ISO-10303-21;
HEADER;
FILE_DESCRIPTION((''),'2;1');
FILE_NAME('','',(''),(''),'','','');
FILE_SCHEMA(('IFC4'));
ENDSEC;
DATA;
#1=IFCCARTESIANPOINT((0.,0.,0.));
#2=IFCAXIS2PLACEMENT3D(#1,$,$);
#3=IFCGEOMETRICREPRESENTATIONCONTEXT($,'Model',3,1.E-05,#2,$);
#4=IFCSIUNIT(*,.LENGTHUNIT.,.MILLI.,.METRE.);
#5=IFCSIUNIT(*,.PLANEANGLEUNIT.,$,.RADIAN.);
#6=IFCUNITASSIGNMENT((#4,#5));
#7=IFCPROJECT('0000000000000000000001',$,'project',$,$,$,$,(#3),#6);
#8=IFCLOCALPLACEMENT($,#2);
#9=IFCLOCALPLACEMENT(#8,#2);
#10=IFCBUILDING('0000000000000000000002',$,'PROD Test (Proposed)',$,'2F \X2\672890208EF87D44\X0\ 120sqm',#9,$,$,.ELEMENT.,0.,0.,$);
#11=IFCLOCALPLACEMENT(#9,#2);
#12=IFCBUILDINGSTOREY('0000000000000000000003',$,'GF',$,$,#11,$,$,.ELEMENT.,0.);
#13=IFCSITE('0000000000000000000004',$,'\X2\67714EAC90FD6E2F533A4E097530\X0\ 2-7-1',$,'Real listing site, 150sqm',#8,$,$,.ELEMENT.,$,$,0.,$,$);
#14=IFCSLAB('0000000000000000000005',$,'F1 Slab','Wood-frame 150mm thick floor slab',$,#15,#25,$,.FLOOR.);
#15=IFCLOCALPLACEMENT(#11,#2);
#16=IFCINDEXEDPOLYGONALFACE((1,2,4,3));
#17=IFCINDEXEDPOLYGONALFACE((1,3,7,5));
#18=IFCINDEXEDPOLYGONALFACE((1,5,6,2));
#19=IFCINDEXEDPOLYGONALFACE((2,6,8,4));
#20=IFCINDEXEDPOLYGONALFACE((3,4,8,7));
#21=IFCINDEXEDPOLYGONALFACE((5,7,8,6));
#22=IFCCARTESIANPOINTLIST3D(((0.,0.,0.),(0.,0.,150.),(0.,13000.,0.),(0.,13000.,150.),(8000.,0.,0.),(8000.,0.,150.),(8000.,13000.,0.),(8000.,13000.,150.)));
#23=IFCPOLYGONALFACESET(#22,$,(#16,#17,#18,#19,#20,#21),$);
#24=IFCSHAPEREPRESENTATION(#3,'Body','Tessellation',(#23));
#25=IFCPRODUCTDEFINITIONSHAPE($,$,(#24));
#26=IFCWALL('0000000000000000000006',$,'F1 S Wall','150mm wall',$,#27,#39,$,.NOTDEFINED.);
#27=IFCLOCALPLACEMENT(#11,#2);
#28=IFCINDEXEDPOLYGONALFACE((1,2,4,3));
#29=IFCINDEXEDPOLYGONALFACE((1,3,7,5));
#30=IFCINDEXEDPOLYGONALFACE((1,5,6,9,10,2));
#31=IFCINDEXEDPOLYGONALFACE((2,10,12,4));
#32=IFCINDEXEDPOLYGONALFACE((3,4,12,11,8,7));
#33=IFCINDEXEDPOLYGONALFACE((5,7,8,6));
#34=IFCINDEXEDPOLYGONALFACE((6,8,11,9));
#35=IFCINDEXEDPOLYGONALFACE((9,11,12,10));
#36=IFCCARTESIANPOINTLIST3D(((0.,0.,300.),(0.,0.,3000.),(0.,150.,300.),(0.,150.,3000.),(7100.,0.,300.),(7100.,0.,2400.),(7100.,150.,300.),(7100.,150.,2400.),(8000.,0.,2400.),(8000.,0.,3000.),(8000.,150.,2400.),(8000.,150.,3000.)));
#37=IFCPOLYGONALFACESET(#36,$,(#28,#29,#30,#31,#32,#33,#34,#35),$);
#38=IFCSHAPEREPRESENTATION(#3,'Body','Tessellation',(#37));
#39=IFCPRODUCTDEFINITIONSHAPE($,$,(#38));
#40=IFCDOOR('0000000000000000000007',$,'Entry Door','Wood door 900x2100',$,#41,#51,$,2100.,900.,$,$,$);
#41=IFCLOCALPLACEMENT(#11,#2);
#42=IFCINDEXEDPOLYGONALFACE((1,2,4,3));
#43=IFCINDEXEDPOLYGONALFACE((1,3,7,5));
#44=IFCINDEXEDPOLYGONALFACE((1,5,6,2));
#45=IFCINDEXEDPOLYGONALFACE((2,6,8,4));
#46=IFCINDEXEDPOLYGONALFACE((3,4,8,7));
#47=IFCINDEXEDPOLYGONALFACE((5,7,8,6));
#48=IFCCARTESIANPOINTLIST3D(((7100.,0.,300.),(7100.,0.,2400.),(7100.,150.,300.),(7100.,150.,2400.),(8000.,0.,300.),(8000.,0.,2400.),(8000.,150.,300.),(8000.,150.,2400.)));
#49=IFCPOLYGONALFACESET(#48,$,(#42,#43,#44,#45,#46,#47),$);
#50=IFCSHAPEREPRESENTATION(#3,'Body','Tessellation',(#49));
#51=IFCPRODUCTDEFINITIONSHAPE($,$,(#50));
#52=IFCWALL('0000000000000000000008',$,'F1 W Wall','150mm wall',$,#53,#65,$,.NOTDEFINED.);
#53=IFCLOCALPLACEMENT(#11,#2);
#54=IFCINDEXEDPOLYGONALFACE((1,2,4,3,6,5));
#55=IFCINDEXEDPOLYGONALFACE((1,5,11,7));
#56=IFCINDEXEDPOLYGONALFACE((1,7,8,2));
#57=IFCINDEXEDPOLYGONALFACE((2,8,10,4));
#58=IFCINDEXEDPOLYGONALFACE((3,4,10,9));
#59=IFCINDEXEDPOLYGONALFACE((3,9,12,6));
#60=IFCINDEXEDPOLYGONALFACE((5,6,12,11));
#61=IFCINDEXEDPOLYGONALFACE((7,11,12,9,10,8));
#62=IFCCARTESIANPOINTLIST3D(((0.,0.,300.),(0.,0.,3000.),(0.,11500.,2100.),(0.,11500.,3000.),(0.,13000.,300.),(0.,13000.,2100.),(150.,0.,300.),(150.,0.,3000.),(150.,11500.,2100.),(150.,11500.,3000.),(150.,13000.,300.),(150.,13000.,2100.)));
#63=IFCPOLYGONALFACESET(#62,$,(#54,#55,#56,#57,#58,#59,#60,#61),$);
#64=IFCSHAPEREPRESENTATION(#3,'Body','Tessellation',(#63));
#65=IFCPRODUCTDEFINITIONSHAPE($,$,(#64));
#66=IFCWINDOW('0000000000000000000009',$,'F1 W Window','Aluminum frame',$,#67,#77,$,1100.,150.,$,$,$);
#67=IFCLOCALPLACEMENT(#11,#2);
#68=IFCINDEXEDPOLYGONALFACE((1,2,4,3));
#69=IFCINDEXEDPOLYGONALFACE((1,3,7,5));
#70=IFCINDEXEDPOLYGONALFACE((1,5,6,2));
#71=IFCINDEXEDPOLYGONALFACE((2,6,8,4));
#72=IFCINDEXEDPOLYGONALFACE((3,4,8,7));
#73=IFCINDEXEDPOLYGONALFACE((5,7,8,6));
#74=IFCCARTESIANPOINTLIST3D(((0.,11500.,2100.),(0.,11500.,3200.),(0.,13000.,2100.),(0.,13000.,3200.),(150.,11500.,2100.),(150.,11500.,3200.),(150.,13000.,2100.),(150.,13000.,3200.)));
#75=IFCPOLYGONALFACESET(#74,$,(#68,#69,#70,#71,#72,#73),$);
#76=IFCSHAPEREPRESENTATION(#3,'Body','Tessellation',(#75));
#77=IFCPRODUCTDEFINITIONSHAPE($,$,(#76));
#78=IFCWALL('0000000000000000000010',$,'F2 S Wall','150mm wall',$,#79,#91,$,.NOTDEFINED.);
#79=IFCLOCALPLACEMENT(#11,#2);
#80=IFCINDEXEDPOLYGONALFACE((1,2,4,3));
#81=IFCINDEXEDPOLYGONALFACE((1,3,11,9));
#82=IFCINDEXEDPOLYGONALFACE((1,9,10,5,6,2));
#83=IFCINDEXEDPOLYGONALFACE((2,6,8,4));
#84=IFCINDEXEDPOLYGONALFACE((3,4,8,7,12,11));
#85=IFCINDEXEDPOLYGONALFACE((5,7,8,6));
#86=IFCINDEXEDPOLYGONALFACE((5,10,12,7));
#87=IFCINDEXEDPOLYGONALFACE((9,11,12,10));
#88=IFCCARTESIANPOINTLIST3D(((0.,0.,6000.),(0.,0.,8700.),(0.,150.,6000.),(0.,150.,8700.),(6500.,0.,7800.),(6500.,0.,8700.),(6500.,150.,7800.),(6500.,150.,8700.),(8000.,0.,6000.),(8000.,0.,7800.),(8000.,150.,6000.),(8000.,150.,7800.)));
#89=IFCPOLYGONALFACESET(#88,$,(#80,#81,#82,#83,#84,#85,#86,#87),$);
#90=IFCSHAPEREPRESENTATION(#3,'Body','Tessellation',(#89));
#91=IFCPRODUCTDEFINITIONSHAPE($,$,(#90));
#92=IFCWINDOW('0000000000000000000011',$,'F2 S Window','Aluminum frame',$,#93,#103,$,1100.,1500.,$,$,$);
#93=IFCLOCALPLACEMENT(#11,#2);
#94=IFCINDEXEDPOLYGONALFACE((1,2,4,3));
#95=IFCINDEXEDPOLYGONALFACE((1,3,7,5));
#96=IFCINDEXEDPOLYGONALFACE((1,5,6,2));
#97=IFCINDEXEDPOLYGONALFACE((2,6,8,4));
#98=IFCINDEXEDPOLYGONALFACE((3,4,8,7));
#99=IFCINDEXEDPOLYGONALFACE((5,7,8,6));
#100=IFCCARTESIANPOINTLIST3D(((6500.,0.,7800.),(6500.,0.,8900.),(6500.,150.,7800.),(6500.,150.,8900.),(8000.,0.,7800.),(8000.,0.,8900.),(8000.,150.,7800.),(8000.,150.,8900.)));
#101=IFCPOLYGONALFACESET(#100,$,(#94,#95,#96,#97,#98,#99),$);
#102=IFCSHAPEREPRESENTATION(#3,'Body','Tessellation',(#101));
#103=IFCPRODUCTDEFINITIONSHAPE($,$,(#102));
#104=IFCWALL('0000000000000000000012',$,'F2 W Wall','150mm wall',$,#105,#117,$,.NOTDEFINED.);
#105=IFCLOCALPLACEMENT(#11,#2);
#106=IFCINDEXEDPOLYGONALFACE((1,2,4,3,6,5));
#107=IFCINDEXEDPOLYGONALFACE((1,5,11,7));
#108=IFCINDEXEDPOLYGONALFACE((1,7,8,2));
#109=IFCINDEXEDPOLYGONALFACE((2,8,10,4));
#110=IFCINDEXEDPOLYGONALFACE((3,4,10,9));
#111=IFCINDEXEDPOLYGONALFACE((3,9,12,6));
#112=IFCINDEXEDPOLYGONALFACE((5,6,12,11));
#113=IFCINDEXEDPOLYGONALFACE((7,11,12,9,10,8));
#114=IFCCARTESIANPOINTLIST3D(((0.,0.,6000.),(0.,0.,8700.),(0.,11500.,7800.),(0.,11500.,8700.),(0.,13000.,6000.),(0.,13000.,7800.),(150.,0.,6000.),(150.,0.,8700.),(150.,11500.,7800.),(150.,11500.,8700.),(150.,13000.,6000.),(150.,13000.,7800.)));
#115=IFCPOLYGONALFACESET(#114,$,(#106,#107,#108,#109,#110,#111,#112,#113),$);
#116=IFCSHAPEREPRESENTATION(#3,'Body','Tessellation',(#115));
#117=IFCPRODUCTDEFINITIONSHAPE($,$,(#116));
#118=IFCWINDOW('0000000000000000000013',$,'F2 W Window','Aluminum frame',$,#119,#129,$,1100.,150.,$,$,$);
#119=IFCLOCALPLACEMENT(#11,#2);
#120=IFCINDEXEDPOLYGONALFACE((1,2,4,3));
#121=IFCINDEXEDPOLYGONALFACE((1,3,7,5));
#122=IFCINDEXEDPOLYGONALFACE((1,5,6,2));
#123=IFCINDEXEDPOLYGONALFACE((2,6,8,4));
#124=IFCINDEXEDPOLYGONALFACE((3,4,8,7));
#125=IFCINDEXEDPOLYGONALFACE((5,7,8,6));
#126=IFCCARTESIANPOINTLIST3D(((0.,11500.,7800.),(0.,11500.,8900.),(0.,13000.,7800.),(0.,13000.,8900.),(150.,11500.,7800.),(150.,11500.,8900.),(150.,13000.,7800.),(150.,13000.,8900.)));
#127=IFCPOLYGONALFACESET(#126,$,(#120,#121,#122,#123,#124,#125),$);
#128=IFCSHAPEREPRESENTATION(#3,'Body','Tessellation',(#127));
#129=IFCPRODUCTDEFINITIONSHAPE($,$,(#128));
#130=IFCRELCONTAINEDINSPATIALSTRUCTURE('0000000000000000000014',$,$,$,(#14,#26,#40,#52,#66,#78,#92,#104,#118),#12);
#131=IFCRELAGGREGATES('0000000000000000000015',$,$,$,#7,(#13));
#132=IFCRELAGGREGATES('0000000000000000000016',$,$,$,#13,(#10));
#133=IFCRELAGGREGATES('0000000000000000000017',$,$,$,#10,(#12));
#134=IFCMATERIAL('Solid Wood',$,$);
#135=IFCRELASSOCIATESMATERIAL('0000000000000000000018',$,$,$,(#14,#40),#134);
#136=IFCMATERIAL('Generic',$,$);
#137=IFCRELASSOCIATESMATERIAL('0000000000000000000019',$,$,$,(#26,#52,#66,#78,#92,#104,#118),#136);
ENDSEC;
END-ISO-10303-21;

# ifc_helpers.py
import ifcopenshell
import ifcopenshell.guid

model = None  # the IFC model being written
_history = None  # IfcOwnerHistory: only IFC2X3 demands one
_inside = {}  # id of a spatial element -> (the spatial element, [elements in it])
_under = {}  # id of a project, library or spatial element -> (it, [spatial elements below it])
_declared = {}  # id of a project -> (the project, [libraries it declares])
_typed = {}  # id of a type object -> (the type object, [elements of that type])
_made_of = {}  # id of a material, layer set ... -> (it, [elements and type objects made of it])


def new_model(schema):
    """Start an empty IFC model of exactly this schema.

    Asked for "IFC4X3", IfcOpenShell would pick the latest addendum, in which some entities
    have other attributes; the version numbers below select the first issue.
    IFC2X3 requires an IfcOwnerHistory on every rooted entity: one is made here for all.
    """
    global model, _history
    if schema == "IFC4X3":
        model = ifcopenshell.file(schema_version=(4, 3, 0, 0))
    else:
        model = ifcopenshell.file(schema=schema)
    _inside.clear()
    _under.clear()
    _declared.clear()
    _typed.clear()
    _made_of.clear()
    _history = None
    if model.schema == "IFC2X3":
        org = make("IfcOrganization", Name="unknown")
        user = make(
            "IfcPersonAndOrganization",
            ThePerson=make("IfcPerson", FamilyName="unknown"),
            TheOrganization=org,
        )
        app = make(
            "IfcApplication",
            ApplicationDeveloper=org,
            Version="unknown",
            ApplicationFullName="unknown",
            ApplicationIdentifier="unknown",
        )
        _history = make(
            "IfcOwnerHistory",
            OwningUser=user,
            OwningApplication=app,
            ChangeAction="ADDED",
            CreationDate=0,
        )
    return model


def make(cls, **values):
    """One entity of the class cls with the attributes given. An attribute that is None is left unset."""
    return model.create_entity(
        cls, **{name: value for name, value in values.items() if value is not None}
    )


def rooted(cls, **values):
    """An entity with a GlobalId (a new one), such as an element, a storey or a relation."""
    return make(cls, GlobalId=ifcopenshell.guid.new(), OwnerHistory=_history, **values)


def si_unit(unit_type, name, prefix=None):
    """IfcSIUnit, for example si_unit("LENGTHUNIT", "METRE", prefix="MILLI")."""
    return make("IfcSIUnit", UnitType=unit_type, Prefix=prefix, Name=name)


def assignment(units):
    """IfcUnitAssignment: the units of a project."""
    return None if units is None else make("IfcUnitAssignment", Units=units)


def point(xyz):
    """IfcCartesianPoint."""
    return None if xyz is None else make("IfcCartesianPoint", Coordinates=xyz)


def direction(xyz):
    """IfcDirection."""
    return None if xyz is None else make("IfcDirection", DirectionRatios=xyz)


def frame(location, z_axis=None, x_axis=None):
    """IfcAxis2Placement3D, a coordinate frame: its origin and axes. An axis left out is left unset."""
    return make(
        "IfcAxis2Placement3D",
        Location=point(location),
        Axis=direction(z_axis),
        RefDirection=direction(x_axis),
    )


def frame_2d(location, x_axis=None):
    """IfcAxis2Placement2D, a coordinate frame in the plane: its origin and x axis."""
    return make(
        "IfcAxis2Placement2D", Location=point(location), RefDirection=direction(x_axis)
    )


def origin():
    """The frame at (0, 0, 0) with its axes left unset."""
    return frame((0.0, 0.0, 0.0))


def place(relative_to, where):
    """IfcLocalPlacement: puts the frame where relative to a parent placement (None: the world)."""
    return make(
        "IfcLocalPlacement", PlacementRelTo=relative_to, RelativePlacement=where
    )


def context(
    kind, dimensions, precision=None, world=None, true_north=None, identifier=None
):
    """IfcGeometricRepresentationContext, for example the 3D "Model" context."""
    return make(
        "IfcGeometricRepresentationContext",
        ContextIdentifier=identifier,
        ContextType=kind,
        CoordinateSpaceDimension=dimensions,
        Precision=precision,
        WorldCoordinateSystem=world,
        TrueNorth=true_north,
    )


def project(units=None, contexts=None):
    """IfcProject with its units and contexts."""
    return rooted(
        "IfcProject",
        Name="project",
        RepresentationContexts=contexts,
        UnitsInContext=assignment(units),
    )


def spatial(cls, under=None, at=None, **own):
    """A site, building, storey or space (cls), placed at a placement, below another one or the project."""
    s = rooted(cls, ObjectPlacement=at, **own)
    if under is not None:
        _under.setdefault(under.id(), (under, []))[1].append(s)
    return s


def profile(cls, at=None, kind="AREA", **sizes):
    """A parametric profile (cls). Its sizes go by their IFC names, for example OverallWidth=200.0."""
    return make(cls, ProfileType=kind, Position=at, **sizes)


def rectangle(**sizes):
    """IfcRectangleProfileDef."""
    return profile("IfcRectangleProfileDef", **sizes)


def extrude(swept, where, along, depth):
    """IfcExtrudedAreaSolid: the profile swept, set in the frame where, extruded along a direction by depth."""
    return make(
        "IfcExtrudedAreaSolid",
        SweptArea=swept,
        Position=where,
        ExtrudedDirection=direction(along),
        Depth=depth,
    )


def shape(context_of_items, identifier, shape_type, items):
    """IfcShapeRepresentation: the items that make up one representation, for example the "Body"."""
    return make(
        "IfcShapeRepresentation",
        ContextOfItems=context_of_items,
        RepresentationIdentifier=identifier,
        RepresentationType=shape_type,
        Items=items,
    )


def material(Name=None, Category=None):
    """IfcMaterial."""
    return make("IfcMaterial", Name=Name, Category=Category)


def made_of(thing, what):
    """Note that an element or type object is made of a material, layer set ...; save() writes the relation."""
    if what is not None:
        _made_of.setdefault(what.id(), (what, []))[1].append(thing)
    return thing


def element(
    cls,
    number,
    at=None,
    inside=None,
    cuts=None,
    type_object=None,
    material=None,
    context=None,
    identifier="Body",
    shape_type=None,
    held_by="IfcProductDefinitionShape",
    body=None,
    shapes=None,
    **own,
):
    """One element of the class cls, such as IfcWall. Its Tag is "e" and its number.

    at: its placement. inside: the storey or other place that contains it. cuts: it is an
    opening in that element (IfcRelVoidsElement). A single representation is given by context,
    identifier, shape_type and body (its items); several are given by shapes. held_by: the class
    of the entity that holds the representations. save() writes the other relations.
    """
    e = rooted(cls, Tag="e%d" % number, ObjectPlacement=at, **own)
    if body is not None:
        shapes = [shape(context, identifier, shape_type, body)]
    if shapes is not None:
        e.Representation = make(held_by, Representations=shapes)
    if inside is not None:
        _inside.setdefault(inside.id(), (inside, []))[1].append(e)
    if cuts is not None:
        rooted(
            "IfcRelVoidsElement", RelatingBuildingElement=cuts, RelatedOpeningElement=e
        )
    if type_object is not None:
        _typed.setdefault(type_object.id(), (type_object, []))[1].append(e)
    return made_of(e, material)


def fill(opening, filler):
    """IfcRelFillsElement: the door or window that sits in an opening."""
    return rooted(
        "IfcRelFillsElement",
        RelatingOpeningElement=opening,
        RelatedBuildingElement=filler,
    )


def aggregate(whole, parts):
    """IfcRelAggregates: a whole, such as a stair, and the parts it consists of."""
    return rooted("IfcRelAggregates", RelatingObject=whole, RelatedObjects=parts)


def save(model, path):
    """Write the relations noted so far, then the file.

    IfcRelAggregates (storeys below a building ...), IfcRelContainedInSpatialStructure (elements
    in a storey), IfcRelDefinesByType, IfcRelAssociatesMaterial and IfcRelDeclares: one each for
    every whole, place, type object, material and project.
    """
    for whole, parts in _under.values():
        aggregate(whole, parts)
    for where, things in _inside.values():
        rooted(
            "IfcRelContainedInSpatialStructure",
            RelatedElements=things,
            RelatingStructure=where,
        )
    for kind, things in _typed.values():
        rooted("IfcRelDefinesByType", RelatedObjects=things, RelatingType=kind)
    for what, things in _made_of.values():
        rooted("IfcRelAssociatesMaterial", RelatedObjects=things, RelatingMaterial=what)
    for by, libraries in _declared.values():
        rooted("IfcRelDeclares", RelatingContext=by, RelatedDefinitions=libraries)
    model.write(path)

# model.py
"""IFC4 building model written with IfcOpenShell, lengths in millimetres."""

from ifc_helpers import new_model, si_unit, frame, frame_2d, origin, place, context, project, spatial, rectangle, extrude, material, element, fill, save


model = new_model("IFC4")

# Units and contexts
model_context = context("Model", 3, precision=1e-05, world=origin())
ifc_project = project(units=[si_unit("LENGTHUNIT", "METRE", prefix="MILLI"), si_unit("PLANEANGLEUNIT", "RADIAN")], contexts=[model_context])

# Site, building, storey
site_placement = place(None, origin())
site = spatial("IfcSite", under=ifc_project, at=site_placement, Name="東京都港区三田 2-7-1", ObjectType="Real listing site, 150sqm", CompositionType="ELEMENT", RefElevation=0.0)
building_placement = place(site_placement, origin())
building = spatial("IfcBuilding", under=site, at=building_placement, Name="PROD Test (Proposed)", ObjectType="2F 木造軸組 120sqm", CompositionType="ELEMENT", ElevationOfRefHeight=0.0, ElevationOfTerrain=0.0)
storey_placement = place(building_placement, origin())
storey = spatial("IfcBuildingStorey", under=building, at=storey_placement, Name="GF", CompositionType="ELEMENT", Elevation=0.0)

# Slab
ifc_material_1 = material(Name="Solid Wood")
slab_1_placement = place(storey_placement, origin())
element("IfcSlab", 1, at=slab_1_placement, inside=storey, material=ifc_material_1, Name="F1 Slab", Description="Wood-frame 150mm thick floor slab", PredefinedType="FLOOR", context=model_context, shape_type="SweptSolid", body=[
    extrude(rectangle(XDim=8000.0, YDim=13000.0, at=frame_2d((4000.0, 6500.0))), origin(), (0.0, 0.0, 1.0), 150.0),
])

# Shared definitions
ifc_material_2 = material(Name="Generic")

# Wall, opening, door
wall_1_placement = place(storey_placement, frame((0.0, 0.0, 150.0)))
wall_1 = element("IfcWall", 2, at=wall_1_placement, inside=storey, material=ifc_material_2, Name="F1 S Wall", Description="150mm wall", PredefinedType="NOTDEFINED", context=model_context, shape_type="SweptSolid", body=[
    extrude(rectangle(XDim=8000.0, YDim=150.0, at=frame_2d((4000.0, 75.0))), frame((0.0, 0.0, 150.0)), (0.0, 0.0, 1.0), 2700.0),
])
opening_1_placement = place(storey_placement, frame((3550.0, 0.0, 150.0)))
opening_1 = element("IfcOpeningElement", 3, at=opening_1_placement, cuts=wall_1, PredefinedType="NOTDEFINED", context=model_context, shape_type="SweptSolid", body=[
    extrude(rectangle(XDim=900.0, YDim=150.0, at=frame_2d((450.0, 75.0))), frame((3550.0, 0.0, 150.0)), (0.0, 0.0, 1.0), 2100.0),
])
door_placement = place(storey_placement, frame((3550.0, 0.0, 150.0)))
door = element("IfcDoor", 4, at=door_placement, inside=storey, material=ifc_material_1, Name="Entry Door", Description="Wood door 900x2100", OverallHeight=2100.0, OverallWidth=900.0, context=model_context, shape_type="SweptSolid", body=[
    extrude(rectangle(XDim=900.0, YDim=150.0, at=frame_2d((450.0, 75.0))), frame((3550.0, 0.0, 150.0)), (0.0, 0.0, 1.0), 2100.0),
])
fill(opening_1, door)

# Walls, openings, windows
wall_2_placement = place(storey_placement, frame((0.0, 0.0, 150.0)))
wall_2 = element("IfcWall", 5, at=wall_2_placement, inside=storey, material=ifc_material_2, Name="F1 W Wall", Description="150mm wall", PredefinedType="NOTDEFINED", context=model_context, shape_type="SweptSolid", body=[
    extrude(rectangle(XDim=150.0, YDim=13000.0, at=frame_2d((75.0, 6500.0))), frame((0.0, 0.0, 150.0)), (0.0, 0.0, 1.0), 2700.0),
])
opening_2_placement = place(storey_placement, frame((0.0, 5750.0, 1050.0)))
opening_2 = element("IfcOpeningElement", 6, at=opening_2_placement, cuts=wall_2, PredefinedType="NOTDEFINED", context=model_context, shape_type="SweptSolid", body=[
    extrude(rectangle(XDim=150.0, YDim=1500.0, at=frame_2d((75.0, 750.0))), frame((0.0, 5750.0, 1050.0)), (0.0, 0.0, 1.0), 1100.0),
])
window_1_placement = place(storey_placement, frame((0.0, 5750.0, 1050.0)))
window_1 = element("IfcWindow", 7, at=window_1_placement, inside=storey, material=ifc_material_2, Name="F1 W Window", Description="Aluminum frame", OverallHeight=1100.0, OverallWidth=150.0, context=model_context, shape_type="SweptSolid", body=[
    extrude(rectangle(XDim=150.0, YDim=1500.0, at=frame_2d((75.0, 750.0))), frame((0.0, 5750.0, 1050.0)), (0.0, 0.0, 1.0), 1100.0),
])
fill(opening_2, window_1)
wall_3_placement = place(storey_placement, frame((0.0, 0.0, 3000.0)))
wall_3 = element("IfcWall", 8, at=wall_3_placement, inside=storey, material=ifc_material_2, Name="F2 S Wall", Description="150mm wall", PredefinedType="NOTDEFINED", context=model_context, shape_type="SweptSolid", body=[
    extrude(rectangle(XDim=8000.0, YDim=150.0, at=frame_2d((4000.0, 75.0))), frame((0.0, 0.0, 3000.0)), (0.0, 0.0, 1.0), 2700.0),
])
opening_3_placement = place(storey_placement, frame((3250.0, 0.0, 3900.0)))
opening_3 = element("IfcOpeningElement", 9, at=opening_3_placement, cuts=wall_3, PredefinedType="NOTDEFINED", context=model_context, shape_type="SweptSolid", body=[
    extrude(rectangle(XDim=1500.0, YDim=150.0, at=frame_2d((750.0, 75.0))), frame((3250.0, 0.0, 3900.0)), (0.0, 0.0, 1.0), 1100.0),
])
window_2_placement = place(storey_placement, frame((3250.0, 0.0, 3900.0)))
window_2 = element("IfcWindow", 10, at=window_2_placement, inside=storey, material=ifc_material_2, Name="F2 S Window", Description="Aluminum frame", OverallHeight=1100.0, OverallWidth=1500.0, context=model_context, shape_type="SweptSolid", body=[
    extrude(rectangle(XDim=1500.0, YDim=150.0, at=frame_2d((750.0, 75.0))), frame((3250.0, 0.0, 3900.0)), (0.0, 0.0, 1.0), 1100.0),
])
fill(opening_3, window_2)
wall_4_placement = place(storey_placement, frame((0.0, 0.0, 3000.0)))
wall_4 = element("IfcWall", 11, at=wall_4_placement, inside=storey, material=ifc_material_2, Name="F2 W Wall", Description="150mm wall", PredefinedType="NOTDEFINED", context=model_context, shape_type="SweptSolid", body=[
    extrude(rectangle(XDim=150.0, YDim=13000.0, at=frame_2d((75.0, 6500.0))), frame((0.0, 0.0, 3000.0)), (0.0, 0.0, 1.0), 2700.0),
])
opening_4_placement = place(storey_placement, frame((0.0, 5750.0, 3900.0)))
opening_4 = element("IfcOpeningElement", 12, at=opening_4_placement, cuts=wall_4, PredefinedType="NOTDEFINED", context=model_context, shape_type="SweptSolid", body=[
    extrude(rectangle(XDim=150.0, YDim=1500.0, at=frame_2d((75.0, 750.0))), frame((0.0, 5750.0, 3900.0)), (0.0, 0.0, 1.0), 1100.0),
])
window_3_placement = place(storey_placement, frame((0.0, 5750.0, 3900.0)))
window_3 = element("IfcWindow", 13, at=window_3_placement, inside=storey, material=ifc_material_2, Name="F2 W Window", Description="Aluminum frame", OverallHeight=1100.0, OverallWidth=150.0, context=model_context, shape_type="SweptSolid", body=[
    extrude(rectangle(XDim=150.0, YDim=1500.0, at=frame_2d((75.0, 750.0))), frame((0.0, 5750.0, 3900.0)), (0.0, 0.0, 1.0), 1100.0),
])
fill(opening_4, window_3)

save(model, "model.ifc")
